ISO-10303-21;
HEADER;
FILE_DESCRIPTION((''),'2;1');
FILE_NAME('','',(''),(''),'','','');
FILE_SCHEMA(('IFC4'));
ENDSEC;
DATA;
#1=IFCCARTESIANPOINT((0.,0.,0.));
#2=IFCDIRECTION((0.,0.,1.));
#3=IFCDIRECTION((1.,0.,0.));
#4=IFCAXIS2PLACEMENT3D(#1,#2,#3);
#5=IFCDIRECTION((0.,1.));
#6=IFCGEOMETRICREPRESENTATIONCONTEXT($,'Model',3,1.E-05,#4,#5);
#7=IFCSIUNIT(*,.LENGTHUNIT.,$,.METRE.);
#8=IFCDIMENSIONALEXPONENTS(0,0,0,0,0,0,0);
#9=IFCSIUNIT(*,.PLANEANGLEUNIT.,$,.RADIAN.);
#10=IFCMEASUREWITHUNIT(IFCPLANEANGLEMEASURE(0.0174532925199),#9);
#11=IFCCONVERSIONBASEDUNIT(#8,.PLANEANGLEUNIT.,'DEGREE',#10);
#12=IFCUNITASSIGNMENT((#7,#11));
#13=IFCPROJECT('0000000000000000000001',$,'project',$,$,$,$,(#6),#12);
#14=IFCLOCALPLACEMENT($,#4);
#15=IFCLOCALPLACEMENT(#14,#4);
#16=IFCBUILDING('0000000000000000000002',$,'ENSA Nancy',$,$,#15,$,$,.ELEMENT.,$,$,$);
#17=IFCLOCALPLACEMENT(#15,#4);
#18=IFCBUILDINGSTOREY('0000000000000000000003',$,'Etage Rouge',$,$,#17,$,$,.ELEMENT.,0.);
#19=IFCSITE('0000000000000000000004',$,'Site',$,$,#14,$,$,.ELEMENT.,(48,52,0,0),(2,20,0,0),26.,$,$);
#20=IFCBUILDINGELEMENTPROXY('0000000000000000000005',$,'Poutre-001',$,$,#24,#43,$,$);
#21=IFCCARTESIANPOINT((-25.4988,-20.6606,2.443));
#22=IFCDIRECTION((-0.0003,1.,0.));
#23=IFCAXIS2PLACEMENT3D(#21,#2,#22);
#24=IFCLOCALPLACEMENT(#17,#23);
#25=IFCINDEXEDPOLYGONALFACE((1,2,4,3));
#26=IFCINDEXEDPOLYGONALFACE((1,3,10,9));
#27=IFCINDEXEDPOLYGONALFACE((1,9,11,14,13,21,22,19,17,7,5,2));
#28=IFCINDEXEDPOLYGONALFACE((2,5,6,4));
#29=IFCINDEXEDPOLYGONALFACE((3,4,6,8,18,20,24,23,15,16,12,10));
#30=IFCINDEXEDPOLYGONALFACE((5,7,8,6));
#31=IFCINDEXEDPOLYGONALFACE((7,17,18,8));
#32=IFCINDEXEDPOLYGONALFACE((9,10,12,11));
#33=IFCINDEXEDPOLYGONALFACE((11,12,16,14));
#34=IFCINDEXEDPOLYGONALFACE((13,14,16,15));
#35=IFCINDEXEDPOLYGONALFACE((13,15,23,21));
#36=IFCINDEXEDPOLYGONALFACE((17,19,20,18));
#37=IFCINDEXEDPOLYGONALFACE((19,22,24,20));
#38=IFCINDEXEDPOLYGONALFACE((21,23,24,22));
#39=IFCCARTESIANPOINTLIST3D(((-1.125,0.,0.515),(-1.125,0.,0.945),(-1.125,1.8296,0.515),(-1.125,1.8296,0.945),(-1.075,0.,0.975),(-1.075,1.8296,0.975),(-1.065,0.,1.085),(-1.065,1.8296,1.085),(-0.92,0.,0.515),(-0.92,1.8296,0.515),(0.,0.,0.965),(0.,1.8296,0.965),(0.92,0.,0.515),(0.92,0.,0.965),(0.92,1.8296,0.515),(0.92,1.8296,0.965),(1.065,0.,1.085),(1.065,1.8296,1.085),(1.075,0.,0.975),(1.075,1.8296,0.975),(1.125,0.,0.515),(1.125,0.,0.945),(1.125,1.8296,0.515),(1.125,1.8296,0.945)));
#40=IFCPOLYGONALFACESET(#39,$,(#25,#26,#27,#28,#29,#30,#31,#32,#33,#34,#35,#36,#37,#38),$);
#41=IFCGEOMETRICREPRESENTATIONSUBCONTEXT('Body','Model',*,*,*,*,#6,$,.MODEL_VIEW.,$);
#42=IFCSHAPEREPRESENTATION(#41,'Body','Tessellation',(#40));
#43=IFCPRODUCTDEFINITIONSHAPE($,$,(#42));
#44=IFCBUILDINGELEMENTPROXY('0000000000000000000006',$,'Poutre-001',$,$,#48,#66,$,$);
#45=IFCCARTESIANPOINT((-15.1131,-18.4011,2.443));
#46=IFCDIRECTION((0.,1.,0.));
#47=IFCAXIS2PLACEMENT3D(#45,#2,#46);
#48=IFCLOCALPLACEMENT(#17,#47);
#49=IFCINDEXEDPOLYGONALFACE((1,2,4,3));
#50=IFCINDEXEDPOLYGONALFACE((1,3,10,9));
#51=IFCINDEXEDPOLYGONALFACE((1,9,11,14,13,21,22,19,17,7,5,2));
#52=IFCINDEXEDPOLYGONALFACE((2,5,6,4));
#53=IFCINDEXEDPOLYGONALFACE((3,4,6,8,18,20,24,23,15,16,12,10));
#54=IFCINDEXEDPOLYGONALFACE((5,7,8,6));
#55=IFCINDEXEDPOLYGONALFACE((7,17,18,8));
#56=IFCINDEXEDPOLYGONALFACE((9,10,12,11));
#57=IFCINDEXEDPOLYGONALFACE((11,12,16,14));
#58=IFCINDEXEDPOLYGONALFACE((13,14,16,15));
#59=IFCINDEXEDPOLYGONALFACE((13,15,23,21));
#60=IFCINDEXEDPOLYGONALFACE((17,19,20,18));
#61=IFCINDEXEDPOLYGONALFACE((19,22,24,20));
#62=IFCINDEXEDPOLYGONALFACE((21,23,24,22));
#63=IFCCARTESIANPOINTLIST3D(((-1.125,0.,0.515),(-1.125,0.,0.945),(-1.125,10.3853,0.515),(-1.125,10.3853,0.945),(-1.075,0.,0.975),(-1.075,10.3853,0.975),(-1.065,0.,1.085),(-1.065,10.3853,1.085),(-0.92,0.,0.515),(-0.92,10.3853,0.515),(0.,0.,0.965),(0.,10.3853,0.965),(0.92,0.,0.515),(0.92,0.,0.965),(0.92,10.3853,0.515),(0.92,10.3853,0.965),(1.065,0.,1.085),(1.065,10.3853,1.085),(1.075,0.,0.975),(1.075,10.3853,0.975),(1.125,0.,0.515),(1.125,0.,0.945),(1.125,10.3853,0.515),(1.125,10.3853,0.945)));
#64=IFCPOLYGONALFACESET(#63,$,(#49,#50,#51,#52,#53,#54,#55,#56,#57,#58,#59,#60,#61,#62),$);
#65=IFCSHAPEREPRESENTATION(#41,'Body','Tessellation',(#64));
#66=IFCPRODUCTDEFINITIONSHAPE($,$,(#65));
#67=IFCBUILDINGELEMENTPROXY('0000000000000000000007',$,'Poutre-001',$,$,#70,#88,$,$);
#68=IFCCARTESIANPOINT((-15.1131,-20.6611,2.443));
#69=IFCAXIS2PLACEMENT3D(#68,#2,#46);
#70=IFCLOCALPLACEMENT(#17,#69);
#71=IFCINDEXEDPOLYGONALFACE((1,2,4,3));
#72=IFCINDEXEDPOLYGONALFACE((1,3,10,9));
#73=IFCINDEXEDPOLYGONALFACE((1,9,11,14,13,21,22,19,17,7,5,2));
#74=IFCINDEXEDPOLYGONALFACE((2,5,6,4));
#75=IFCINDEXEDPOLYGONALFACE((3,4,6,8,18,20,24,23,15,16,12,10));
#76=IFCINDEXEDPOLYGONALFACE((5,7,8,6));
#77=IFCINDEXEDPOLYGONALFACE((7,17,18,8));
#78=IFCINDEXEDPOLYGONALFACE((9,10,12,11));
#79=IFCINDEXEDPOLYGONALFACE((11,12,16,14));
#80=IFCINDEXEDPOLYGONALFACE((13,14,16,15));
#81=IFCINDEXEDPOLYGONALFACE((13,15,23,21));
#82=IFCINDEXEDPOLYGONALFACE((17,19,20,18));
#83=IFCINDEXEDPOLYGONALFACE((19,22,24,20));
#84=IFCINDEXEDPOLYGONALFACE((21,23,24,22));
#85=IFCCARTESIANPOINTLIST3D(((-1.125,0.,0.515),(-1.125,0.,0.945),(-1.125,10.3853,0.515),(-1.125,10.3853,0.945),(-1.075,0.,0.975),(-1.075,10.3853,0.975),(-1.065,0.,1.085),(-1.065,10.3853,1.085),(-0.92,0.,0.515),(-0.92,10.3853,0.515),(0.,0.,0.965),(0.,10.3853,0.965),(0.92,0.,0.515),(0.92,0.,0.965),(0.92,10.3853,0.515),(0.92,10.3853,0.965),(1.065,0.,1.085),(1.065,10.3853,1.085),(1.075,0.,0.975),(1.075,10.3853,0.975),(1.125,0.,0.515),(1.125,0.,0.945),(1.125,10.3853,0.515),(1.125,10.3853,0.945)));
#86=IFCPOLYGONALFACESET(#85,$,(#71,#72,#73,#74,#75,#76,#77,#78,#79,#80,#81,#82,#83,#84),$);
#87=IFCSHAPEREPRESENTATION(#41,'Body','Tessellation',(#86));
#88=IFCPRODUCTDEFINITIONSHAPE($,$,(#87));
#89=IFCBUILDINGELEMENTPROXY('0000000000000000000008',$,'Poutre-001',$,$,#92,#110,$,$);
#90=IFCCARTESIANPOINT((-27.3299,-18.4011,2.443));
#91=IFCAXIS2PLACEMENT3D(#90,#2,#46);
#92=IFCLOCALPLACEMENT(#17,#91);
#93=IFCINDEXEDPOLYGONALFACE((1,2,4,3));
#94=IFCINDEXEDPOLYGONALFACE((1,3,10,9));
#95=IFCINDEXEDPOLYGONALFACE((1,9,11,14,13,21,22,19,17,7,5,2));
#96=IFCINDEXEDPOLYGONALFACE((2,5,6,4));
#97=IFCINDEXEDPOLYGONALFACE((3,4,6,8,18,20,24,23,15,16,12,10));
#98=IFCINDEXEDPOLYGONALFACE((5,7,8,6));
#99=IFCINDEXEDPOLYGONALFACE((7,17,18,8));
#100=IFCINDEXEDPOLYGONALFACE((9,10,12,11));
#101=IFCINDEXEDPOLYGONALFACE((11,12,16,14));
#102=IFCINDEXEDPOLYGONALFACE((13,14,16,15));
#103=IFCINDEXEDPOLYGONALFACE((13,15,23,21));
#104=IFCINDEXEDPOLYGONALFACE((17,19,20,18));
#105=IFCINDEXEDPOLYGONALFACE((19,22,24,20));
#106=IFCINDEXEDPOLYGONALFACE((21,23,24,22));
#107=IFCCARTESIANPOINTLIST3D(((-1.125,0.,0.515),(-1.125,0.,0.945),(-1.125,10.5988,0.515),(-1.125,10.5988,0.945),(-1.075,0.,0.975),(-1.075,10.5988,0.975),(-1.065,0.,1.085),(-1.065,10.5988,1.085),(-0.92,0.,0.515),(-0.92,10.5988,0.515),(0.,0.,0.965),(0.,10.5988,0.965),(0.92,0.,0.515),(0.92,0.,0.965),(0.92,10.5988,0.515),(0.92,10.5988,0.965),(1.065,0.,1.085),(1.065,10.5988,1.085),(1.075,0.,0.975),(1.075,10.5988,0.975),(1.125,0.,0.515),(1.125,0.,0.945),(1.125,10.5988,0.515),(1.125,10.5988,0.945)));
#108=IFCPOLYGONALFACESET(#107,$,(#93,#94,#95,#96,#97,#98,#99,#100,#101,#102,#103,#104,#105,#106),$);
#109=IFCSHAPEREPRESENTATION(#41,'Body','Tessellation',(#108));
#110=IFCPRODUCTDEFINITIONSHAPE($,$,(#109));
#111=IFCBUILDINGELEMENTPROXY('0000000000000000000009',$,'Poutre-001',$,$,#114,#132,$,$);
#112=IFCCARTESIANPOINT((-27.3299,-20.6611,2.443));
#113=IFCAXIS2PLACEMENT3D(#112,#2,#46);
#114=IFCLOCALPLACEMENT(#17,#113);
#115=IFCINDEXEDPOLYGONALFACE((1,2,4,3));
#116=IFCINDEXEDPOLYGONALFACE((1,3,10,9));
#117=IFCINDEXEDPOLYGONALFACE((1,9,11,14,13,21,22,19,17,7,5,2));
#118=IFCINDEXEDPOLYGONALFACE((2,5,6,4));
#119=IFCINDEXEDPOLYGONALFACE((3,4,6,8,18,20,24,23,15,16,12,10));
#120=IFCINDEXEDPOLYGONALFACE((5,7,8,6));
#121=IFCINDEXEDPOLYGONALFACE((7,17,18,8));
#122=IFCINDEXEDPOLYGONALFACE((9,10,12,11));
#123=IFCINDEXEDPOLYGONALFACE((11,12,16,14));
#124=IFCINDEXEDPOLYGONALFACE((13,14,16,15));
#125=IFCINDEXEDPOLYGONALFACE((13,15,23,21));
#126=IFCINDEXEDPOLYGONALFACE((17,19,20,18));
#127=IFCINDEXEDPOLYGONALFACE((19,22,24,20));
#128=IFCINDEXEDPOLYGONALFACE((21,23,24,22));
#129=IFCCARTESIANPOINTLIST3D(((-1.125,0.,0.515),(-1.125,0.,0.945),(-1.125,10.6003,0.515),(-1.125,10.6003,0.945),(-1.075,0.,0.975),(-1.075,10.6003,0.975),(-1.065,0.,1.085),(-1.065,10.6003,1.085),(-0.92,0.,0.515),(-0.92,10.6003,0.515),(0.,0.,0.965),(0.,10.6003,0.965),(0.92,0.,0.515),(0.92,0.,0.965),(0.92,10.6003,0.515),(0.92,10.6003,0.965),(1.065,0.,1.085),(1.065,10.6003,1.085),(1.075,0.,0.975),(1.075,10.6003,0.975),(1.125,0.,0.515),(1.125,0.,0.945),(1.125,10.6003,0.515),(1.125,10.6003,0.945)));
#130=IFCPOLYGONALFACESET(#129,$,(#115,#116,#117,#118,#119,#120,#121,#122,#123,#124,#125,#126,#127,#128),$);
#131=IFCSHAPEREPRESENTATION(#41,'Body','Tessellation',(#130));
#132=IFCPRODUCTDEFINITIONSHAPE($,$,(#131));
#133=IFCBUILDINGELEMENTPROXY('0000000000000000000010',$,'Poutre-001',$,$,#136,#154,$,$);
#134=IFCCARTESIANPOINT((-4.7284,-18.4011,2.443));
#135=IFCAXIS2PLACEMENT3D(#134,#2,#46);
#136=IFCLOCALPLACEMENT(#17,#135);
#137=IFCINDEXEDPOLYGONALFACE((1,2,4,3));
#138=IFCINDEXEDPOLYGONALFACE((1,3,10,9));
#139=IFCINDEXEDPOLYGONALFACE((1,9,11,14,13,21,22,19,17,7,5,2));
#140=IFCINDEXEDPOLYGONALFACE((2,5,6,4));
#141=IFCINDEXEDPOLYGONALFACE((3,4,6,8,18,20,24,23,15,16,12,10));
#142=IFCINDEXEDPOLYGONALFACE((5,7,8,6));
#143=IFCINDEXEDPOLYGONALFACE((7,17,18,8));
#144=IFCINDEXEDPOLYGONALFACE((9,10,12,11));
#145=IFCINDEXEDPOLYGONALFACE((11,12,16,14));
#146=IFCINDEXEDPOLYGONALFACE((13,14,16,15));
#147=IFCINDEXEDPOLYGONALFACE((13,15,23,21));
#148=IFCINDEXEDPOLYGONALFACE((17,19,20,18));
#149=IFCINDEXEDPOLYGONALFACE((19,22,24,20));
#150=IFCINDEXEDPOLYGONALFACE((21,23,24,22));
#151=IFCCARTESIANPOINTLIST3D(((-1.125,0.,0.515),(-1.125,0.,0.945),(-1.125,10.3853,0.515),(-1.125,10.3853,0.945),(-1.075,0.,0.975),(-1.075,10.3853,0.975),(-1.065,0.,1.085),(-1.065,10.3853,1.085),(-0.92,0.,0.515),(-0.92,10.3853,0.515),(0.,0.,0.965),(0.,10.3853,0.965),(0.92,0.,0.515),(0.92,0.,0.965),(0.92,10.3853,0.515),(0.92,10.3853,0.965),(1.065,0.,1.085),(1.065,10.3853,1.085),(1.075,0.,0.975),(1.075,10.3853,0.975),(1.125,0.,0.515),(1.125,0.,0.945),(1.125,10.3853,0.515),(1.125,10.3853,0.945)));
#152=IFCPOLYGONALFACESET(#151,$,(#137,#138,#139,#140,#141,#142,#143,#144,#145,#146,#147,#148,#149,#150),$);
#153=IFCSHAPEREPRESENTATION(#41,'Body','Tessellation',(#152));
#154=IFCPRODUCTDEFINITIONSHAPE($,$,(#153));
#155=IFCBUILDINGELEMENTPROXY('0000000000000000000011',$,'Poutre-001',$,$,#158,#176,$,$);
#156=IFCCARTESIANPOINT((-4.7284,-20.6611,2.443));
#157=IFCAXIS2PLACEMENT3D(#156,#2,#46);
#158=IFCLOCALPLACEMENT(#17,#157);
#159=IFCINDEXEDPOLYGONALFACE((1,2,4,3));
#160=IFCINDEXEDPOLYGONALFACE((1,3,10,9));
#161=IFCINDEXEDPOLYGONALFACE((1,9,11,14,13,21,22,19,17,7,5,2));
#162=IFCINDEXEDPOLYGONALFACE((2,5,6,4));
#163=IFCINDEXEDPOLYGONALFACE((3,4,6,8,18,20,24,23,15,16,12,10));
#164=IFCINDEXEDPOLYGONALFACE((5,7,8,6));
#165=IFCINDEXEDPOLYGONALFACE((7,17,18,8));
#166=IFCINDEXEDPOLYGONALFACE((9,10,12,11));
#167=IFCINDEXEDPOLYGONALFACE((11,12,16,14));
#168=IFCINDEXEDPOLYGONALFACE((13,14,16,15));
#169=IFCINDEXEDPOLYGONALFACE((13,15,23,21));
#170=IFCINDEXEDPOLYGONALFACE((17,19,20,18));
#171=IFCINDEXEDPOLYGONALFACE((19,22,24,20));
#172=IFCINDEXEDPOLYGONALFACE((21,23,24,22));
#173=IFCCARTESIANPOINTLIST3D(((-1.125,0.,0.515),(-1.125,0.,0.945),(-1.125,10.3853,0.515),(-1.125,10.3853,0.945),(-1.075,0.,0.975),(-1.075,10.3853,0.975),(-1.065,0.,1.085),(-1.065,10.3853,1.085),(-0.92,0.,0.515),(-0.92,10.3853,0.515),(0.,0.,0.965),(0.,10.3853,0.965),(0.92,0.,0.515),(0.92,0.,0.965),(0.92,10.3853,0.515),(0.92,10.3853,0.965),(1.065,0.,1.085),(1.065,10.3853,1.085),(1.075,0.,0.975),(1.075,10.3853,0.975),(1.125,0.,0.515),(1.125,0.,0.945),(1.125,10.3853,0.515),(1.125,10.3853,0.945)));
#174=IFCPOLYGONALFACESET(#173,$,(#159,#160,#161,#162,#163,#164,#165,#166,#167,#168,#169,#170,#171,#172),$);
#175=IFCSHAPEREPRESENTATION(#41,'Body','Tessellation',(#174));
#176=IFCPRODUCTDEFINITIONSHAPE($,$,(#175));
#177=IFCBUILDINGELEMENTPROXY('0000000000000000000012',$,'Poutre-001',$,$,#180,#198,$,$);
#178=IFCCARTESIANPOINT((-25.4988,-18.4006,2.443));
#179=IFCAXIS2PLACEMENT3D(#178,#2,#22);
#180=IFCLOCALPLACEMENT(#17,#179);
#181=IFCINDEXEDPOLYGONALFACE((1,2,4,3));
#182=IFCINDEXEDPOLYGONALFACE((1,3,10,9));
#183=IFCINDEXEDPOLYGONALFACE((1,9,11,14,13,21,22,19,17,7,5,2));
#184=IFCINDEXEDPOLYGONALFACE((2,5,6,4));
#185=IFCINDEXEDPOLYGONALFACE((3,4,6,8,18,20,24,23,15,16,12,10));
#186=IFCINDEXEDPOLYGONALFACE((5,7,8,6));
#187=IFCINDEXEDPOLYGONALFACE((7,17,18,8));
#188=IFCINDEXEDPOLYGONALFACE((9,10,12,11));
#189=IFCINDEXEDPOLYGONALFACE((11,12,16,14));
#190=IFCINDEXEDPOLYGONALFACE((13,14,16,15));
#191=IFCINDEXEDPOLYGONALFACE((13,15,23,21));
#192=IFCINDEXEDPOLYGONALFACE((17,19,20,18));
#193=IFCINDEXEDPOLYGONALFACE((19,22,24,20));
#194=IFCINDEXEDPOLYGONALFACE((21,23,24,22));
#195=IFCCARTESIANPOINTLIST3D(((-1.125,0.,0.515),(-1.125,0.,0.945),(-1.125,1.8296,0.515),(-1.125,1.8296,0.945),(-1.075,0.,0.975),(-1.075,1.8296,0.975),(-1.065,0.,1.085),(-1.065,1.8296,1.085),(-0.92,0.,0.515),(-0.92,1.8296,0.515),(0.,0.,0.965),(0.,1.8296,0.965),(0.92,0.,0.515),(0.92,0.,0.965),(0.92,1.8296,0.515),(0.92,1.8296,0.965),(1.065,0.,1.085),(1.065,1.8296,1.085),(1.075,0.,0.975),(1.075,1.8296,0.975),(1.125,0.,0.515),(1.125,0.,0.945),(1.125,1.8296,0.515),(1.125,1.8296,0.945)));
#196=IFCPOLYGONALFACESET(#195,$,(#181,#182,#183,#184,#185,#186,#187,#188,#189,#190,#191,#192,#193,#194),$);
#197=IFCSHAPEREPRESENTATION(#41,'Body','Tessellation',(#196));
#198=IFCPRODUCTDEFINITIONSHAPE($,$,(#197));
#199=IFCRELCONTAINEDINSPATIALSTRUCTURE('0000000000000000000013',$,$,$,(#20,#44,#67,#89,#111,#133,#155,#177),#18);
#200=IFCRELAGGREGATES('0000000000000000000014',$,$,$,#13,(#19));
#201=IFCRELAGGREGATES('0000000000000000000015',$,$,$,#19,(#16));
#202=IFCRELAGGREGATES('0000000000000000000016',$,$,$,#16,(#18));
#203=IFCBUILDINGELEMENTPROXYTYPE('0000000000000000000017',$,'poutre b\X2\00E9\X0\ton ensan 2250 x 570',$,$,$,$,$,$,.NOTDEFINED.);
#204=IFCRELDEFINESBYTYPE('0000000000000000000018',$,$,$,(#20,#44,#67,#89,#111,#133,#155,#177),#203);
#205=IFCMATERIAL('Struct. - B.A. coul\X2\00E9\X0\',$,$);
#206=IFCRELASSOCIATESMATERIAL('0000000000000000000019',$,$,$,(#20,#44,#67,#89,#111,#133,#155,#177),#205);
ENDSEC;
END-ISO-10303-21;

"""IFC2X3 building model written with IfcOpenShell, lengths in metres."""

from ifc_helpers import new_model, entity, si_unit, converted_unit, direction, frame, origin_with_axes, place, context, subcontext, project, spatial, polyline, outline, extrude, material, type_object, element, save


model = new_model("IFC2X3")

# Units and contexts
model_context = context("Model", 3, precision=1e-05, world=origin_with_axes(), true_north=direction((0.0, 1.0)))
body_context = subcontext(model_context, "Body", "Model", "MODEL_VIEW")
ifc_project = project(units=[si_unit("LENGTHUNIT", "METRE"), converted_unit("PLANEANGLEUNIT", "DEGREE", entity("IfcPlaneAngleMeasure", 0.0174532925199), si_unit("PLANEANGLEUNIT", "RADIAN"), dimensions=[0, 0, 0, 0, 0, 0, 0])], contexts=[model_context])

# Site, building, storey
site_placement = place(None, origin_with_axes())
site = spatial("IfcSite", under=ifc_project, at=site_placement, Name="Site", CompositionType="ELEMENT", RefLatitude=(48, 52, 0, 0), RefLongitude=(2, 20, 0, 0), RefElevation=26.0)
building_placement = place(site_placement, origin_with_axes())
building = spatial("IfcBuilding", under=site, at=building_placement, Name="ENSA Nancy", CompositionType="ELEMENT")
storey_placement = place(building_placement, origin_with_axes())
storey = spatial("IfcBuildingStorey", under=building, at=storey_placement, Name="Etage Rouge", CompositionType="ELEMENT", Elevation=0.0)

# Building element proxies
ifc_material_1 = material(Name="Struct. - B.A. coulé")
building_element_proxy_type_1 = type_object("IfcBuildingElementProxyType", Name="poutre béton ensan 2250 x 570", PredefinedType="NOTDEFINED")
proxy_1_placement = place(storey_placement, frame((-25.4988, -20.6606, 2.443), z_axis=(0.0, 0.0, 1.0), x_axis=(-0.0003, 1.0, 0.0)))
element("IfcBuildingElementProxy", 1, at=proxy_1_placement, inside=storey, type_object=building_element_proxy_type_1, material=ifc_material_1, Name="Poutre-001", context=body_context, shape_type="SweptSolid", body=[
    extrude(outline(polyline([(-1.065, 1.085), (-1.075, 0.975), (-1.125, 0.945), (-1.125, 0.515), (-0.92, 0.515), (0.0, 0.965), (0.92, 0.965), (0.92, 0.515), (1.125, 0.515), (1.125, 0.945), (1.075, 0.975), (1.065, 1.085), (-1.065, 1.085)])), frame((0.0, 1.8296, 0.0), z_axis=(0.0, -1.0, 0.0), x_axis=(1.0, 0.0, 0.0)), (0.0, 0.0, 1.0), 1.8296),
])
for number, where, z_axis, x_axis, name in (
    (2, (-15.1131, -18.4011, 2.443), (0.0, 0.0, 1.0), (0.0, 1.0, 0.0), "Poutre-001"),
    (3, (-15.1131, -20.6611, 2.443), (0.0, 0.0, 1.0), (0.0, 1.0, 0.0), "Poutre-001"),
):
    element("IfcBuildingElementProxy", number, at=place(storey_placement, frame(where, z_axis=z_axis, x_axis=x_axis)), inside=storey, type_object=building_element_proxy_type_1, material=ifc_material_1, Name=name, context=body_context, shape_type="SweptSolid", body=[
        extrude(outline(polyline([(-1.065, 1.085), (-1.075, 0.975), (-1.125, 0.945), (-1.125, 0.515), (-0.92, 0.515), (0.0, 0.965), (0.92, 0.965), (0.92, 0.515), (1.125, 0.515), (1.125, 0.945), (1.075, 0.975), (1.065, 1.085), (-1.065, 1.085)])), frame((0.0, 10.3853, 0.0), z_axis=(0.0, -1.0, 0.0), x_axis=(1.0, 0.0, 0.0)), (0.0, 0.0, 1.0), 10.3853),
    ])
proxy_2_placement = place(storey_placement, frame((-27.3299, -18.4011, 2.443), z_axis=(0.0, 0.0, 1.0), x_axis=(0.0, 1.0, 0.0)))
element("IfcBuildingElementProxy", 4, at=proxy_2_placement, inside=storey, type_object=building_element_proxy_type_1, material=ifc_material_1, Name="Poutre-001", context=body_context, shape_type="SweptSolid", body=[
    extrude(outline(polyline([(-1.065, 1.085), (-1.075, 0.975), (-1.125, 0.945), (-1.125, 0.515), (-0.92, 0.515), (0.0, 0.965), (0.92, 0.965), (0.92, 0.515), (1.125, 0.515), (1.125, 0.945), (1.075, 0.975), (1.065, 1.085), (-1.065, 1.085)])), frame((0.0, 10.5988, 0.0), z_axis=(0.0, -1.0, 0.0), x_axis=(1.0, 0.0, 0.0)), (0.0, 0.0, 1.0), 10.5988),
])
proxy_3_placement = place(storey_placement, frame((-27.3299, -20.6611, 2.443), z_axis=(0.0, 0.0, 1.0), x_axis=(0.0, 1.0, 0.0)))
element("IfcBuildingElementProxy", 5, at=proxy_3_placement, inside=storey, type_object=building_element_proxy_type_1, material=ifc_material_1, Name="Poutre-001", context=body_context, shape_type="SweptSolid", body=[
    extrude(outline(polyline([(-1.065, 1.085), (-1.075, 0.975), (-1.125, 0.945), (-1.125, 0.515), (-0.92, 0.515), (0.0, 0.965), (0.92, 0.965), (0.92, 0.515), (1.125, 0.515), (1.125, 0.945), (1.075, 0.975), (1.065, 1.085), (-1.065, 1.085)])), frame((0.0, 10.6003, 0.0), z_axis=(0.0, -1.0, 0.0), x_axis=(1.0, 0.0, 0.0)), (0.0, 0.0, 1.0), 10.6003),
])
for number, where, z_axis, x_axis, name in (
    (6, (-4.7284, -18.4011, 2.443), (0.0, 0.0, 1.0), (0.0, 1.0, 0.0), "Poutre-001"),
    (7, (-4.7284, -20.6611, 2.443), (0.0, 0.0, 1.0), (0.0, 1.0, 0.0), "Poutre-001"),
):
    element("IfcBuildingElementProxy", number, at=place(storey_placement, frame(where, z_axis=z_axis, x_axis=x_axis)), inside=storey, type_object=building_element_proxy_type_1, material=ifc_material_1, Name=name, context=body_context, shape_type="SweptSolid", body=[
        extrude(outline(polyline([(-1.065, 1.085), (-1.075, 0.975), (-1.125, 0.945), (-1.125, 0.515), (-0.92, 0.515), (0.0, 0.965), (0.92, 0.965), (0.92, 0.515), (1.125, 0.515), (1.125, 0.945), (1.075, 0.975), (1.065, 1.085), (-1.065, 1.085)])), frame((0.0, 10.3853, 0.0), z_axis=(0.0, -1.0, 0.0), x_axis=(1.0, 0.0, 0.0)), (0.0, 0.0, 1.0), 10.3853),
    ])
proxy_4_placement = place(storey_placement, frame((-25.4988, -18.4006, 2.443), z_axis=(0.0, 0.0, 1.0), x_axis=(-0.0003, 1.0, 0.0)))
element("IfcBuildingElementProxy", 8, at=proxy_4_placement, inside=storey, type_object=building_element_proxy_type_1, material=ifc_material_1, Name="Poutre-001", context=body_context, shape_type="SweptSolid", body=[
    extrude(outline(polyline([(-1.065, 1.085), (-1.075, 0.975), (-1.125, 0.945), (-1.125, 0.515), (-0.92, 0.515), (0.0, 0.965), (0.92, 0.965), (0.92, 0.515), (1.125, 0.515), (1.125, 0.945), (1.075, 0.975), (1.065, 1.085), (-1.065, 1.085)])), frame((0.0, 1.8296, 0.0), z_axis=(0.0, -1.0, 0.0), x_axis=(1.0, 0.0, 0.0)), (0.0, 0.0, 1.0), 1.8296),
])

save(model, "model.ifc")
